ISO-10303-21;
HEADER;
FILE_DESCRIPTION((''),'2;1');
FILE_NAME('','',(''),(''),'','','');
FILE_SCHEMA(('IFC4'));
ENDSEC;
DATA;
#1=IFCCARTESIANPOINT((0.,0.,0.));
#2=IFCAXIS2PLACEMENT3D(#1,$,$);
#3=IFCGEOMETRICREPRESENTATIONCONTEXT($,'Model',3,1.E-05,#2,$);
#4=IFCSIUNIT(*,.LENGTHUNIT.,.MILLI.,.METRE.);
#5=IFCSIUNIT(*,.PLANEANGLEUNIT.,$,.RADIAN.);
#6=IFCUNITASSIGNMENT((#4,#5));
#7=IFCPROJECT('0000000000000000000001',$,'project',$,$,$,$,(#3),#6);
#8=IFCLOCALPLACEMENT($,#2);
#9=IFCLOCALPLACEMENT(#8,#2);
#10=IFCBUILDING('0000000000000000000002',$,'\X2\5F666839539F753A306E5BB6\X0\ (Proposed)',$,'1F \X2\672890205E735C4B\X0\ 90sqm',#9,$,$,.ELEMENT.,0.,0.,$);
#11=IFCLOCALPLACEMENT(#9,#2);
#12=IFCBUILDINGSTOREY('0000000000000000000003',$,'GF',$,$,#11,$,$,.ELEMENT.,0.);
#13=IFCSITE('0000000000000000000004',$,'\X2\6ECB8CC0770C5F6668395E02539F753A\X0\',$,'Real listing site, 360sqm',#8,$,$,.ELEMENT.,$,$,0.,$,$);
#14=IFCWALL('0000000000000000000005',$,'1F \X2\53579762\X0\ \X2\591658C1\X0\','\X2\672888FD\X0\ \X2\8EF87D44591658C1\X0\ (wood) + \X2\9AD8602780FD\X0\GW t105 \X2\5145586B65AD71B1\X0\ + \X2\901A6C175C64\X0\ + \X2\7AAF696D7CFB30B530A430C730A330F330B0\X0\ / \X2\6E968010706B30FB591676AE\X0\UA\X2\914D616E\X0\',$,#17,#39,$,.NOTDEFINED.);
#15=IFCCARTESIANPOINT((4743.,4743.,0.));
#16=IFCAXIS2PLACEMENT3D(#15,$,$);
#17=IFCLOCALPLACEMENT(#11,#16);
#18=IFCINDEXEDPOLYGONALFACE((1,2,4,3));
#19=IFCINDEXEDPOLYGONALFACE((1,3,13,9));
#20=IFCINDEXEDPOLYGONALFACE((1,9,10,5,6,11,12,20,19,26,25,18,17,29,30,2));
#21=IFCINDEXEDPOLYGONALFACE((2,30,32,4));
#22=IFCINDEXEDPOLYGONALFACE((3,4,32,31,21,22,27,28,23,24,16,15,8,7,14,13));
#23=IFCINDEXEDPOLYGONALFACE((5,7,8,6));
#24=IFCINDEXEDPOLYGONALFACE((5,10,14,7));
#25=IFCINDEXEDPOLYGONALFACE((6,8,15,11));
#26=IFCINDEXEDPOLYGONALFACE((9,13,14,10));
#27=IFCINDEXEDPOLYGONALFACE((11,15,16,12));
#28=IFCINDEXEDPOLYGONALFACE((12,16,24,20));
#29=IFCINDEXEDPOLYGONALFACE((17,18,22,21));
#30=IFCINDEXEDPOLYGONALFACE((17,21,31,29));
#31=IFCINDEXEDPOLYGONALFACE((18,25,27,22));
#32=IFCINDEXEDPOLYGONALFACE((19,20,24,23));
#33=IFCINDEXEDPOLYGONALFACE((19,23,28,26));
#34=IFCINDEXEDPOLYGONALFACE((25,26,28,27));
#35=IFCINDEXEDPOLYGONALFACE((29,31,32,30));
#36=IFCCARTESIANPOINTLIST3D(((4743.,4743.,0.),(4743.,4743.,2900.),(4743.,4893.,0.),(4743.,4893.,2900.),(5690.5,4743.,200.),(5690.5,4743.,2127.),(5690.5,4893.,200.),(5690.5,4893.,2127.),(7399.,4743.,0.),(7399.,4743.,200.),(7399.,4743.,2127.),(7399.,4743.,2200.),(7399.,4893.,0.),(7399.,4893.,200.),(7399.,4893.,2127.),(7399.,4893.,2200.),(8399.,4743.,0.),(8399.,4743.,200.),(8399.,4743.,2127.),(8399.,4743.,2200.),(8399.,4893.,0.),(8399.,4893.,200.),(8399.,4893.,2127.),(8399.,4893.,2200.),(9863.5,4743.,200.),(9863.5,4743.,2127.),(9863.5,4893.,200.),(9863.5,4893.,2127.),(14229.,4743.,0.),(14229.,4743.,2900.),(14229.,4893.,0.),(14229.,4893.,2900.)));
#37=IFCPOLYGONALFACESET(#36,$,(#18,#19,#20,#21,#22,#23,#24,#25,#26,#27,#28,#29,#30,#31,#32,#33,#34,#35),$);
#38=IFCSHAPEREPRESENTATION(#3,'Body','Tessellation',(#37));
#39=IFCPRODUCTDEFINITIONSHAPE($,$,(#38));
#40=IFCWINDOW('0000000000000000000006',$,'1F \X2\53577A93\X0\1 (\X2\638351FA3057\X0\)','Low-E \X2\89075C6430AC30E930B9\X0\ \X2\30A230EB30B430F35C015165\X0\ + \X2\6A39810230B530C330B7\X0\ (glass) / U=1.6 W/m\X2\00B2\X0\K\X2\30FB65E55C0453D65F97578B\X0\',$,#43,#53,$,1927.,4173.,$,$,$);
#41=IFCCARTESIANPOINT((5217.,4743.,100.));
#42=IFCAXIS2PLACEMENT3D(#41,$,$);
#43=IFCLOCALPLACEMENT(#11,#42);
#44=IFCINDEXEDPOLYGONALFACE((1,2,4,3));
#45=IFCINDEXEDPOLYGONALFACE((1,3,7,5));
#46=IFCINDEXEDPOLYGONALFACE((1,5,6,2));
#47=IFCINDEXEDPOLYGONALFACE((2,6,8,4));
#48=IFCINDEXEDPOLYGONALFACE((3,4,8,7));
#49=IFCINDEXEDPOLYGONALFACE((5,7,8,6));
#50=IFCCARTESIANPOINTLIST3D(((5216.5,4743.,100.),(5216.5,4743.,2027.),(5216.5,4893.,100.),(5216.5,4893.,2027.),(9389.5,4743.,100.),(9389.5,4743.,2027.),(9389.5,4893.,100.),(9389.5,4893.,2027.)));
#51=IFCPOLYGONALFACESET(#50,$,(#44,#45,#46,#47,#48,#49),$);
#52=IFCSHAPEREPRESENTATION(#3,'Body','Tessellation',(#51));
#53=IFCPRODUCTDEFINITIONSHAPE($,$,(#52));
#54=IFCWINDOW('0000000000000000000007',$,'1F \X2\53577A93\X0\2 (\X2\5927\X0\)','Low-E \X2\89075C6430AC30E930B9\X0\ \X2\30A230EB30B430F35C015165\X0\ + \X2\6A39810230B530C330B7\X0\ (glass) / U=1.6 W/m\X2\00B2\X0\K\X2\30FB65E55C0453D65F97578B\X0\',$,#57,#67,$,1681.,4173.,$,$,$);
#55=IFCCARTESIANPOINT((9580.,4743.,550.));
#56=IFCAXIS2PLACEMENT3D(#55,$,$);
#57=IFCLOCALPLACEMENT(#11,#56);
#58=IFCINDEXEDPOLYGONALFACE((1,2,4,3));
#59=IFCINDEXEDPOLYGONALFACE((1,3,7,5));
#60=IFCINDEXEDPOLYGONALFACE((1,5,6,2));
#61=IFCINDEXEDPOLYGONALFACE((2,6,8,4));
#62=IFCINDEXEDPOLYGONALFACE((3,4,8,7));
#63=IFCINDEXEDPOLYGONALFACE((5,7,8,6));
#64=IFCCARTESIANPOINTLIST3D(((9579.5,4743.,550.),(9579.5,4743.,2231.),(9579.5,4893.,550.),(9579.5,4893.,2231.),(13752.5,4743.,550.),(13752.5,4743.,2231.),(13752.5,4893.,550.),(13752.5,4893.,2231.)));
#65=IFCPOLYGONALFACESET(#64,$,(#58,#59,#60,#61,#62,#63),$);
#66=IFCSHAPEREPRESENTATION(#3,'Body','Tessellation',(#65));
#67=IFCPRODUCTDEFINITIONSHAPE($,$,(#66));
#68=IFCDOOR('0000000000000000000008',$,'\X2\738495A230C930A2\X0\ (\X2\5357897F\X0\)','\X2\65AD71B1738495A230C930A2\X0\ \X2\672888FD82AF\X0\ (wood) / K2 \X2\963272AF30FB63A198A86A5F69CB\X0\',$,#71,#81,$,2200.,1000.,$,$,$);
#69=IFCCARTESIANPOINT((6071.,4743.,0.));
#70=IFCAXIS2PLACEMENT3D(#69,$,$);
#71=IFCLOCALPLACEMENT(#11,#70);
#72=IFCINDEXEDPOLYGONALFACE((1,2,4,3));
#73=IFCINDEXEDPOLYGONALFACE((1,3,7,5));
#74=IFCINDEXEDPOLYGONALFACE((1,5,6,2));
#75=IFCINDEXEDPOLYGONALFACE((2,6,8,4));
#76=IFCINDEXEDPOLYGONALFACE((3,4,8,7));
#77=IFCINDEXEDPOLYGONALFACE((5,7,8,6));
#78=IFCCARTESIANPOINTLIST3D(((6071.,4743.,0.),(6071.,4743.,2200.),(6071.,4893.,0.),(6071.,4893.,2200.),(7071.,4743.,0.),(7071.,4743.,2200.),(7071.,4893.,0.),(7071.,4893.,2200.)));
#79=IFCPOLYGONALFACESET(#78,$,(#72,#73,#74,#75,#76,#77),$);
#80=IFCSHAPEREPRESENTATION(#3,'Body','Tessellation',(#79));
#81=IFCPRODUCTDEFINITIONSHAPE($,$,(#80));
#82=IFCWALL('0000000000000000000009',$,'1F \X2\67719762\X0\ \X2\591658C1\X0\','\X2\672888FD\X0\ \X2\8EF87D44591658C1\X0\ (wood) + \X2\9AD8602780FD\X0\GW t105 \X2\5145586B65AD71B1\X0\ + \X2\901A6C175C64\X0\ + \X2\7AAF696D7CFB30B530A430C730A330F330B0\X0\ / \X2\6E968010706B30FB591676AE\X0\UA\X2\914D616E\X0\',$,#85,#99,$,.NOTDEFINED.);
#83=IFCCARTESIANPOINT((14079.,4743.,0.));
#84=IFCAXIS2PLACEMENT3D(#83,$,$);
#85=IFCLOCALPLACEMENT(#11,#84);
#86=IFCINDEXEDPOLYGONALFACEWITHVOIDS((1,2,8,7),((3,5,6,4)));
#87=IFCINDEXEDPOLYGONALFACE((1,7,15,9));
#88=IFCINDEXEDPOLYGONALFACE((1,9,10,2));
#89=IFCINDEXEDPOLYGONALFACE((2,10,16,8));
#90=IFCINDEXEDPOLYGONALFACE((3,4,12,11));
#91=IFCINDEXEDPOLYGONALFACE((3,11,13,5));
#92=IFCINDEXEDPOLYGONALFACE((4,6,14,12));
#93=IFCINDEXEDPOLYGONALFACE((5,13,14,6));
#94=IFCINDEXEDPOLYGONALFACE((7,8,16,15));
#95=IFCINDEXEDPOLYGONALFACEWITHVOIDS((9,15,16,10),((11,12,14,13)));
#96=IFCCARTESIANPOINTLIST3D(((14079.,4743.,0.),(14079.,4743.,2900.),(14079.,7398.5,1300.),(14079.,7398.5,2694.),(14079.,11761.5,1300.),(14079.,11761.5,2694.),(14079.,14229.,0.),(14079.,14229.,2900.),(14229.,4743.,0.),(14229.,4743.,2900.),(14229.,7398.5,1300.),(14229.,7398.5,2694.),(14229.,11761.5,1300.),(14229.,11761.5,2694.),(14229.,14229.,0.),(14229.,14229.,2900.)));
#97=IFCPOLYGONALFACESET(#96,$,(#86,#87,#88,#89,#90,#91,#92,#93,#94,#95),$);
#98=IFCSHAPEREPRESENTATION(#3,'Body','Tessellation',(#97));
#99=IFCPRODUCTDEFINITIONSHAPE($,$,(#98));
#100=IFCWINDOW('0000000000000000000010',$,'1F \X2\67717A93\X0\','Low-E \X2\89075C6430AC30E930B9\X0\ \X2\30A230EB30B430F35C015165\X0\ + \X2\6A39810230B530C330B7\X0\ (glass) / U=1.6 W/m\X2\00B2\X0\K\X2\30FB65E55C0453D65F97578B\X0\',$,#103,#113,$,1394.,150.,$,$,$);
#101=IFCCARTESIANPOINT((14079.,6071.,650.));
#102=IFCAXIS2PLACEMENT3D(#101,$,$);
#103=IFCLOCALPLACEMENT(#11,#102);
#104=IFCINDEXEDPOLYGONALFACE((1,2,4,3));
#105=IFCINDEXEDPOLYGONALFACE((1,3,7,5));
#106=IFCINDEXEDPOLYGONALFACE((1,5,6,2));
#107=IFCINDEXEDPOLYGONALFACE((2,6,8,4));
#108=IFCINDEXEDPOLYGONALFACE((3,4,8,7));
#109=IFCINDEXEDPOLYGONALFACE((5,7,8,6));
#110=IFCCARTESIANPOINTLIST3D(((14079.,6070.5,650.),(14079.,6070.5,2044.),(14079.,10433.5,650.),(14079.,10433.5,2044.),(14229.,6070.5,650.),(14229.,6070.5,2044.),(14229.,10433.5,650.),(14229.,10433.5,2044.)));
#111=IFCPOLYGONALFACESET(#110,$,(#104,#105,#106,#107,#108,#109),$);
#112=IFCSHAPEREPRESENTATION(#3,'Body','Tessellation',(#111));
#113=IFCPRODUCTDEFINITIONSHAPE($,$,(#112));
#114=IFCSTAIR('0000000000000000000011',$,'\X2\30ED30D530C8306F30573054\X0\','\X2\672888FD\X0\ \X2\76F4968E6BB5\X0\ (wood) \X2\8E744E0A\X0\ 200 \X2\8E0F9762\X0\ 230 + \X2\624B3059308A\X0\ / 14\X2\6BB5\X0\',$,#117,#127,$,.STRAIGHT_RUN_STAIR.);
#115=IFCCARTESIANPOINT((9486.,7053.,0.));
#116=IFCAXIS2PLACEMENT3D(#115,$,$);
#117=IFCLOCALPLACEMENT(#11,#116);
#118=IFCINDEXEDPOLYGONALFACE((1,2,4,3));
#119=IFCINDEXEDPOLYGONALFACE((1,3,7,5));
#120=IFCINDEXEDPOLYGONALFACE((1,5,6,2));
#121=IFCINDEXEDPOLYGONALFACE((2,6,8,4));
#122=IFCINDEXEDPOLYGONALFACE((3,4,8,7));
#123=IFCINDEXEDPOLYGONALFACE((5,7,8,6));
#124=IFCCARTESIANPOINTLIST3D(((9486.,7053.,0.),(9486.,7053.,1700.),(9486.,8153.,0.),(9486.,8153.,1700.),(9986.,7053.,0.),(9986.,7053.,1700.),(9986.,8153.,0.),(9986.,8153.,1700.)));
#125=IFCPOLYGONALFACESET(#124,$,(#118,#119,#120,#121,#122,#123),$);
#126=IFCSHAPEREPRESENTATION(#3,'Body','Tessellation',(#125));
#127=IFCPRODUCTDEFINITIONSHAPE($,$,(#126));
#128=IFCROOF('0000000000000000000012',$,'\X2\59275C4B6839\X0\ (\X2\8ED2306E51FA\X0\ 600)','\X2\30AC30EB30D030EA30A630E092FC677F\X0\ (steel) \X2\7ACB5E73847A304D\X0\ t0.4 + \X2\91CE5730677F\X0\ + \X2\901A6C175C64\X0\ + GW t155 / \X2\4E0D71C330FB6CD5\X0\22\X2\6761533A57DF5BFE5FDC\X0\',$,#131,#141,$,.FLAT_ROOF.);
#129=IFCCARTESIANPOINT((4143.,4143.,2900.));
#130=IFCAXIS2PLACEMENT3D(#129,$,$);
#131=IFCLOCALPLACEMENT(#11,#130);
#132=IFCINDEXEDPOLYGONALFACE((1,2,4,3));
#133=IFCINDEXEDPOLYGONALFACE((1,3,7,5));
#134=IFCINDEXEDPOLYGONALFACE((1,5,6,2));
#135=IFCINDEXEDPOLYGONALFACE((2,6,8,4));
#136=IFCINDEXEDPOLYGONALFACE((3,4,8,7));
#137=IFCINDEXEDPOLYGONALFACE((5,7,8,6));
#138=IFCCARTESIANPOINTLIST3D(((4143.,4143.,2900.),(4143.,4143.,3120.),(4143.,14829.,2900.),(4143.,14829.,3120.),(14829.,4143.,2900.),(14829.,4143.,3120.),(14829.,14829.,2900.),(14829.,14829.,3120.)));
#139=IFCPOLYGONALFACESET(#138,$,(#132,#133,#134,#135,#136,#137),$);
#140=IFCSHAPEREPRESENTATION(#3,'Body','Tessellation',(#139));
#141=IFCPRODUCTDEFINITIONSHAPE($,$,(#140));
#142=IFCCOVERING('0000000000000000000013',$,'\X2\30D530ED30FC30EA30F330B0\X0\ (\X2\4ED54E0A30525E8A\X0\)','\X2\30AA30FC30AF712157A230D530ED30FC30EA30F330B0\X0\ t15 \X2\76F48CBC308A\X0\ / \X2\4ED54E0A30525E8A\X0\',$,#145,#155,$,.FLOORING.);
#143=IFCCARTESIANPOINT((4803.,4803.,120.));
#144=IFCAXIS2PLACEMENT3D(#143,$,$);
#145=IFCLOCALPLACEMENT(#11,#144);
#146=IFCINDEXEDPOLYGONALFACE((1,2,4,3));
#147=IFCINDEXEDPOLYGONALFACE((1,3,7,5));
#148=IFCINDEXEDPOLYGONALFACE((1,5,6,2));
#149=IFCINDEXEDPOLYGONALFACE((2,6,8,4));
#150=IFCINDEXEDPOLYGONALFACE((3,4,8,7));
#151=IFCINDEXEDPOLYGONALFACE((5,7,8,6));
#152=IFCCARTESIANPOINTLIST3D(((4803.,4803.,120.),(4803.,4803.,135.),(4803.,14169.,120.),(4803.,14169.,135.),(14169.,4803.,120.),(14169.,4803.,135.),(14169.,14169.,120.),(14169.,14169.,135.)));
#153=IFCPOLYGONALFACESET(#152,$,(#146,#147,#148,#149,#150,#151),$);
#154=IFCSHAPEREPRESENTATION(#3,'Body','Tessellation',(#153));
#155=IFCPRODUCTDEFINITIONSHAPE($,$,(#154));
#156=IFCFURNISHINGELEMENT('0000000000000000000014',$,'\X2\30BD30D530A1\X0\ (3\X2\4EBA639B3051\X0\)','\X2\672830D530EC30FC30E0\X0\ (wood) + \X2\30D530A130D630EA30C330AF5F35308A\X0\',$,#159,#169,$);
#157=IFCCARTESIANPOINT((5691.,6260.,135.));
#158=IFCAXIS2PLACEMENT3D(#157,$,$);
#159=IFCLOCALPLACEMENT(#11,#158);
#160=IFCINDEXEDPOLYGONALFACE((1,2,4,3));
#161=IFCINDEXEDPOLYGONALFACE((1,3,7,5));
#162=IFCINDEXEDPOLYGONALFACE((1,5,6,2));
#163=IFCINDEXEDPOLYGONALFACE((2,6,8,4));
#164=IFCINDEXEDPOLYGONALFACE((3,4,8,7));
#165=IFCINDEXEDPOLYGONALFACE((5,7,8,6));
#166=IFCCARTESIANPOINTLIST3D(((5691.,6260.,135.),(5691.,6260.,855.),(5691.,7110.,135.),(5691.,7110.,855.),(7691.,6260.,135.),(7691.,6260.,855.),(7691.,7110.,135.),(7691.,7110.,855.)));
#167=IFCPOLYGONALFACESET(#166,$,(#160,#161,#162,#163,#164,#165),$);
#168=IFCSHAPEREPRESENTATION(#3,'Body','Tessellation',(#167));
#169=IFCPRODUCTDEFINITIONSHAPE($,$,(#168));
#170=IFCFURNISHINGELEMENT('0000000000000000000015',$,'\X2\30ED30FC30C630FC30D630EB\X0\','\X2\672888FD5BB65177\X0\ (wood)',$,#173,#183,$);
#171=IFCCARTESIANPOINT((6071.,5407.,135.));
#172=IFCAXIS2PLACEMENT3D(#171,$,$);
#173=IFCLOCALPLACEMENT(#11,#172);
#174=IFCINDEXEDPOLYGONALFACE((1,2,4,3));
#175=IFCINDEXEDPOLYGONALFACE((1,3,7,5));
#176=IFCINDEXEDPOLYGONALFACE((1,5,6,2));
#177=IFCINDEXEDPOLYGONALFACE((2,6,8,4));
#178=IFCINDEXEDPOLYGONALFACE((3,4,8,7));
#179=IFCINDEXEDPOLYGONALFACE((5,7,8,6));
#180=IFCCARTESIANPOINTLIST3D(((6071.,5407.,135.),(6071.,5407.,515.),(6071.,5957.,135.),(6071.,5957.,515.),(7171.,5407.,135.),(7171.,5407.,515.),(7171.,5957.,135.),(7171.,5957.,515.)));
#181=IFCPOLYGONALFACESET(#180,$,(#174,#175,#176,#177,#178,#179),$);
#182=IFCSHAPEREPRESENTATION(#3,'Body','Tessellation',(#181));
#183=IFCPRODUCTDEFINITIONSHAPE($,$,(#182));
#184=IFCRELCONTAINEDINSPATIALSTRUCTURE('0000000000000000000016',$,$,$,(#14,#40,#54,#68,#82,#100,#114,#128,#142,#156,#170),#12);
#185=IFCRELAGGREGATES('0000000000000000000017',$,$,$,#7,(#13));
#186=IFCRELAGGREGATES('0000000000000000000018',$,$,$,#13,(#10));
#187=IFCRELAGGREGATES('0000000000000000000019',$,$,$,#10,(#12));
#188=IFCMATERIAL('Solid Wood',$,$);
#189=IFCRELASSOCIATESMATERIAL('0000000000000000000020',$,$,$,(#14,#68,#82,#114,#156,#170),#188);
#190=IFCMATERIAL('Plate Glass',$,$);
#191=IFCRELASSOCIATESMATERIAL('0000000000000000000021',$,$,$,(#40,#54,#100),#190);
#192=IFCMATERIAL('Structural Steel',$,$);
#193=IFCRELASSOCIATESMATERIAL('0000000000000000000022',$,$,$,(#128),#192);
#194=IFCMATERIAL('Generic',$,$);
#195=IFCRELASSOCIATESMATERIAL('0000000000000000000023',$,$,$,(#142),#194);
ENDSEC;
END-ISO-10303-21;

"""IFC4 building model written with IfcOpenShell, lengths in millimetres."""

from ifc_helpers import new_model, si_unit, frame, frame_2d, origin, place, context, project, spatial, rectangle, extrude, material, element, fill, save


model = new_model("IFC4")

# Units and contexts
model_context = context("Model", 3, precision=1e-05, world=origin())
ifc_project = project(units=[si_unit("LENGTHUNIT", "METRE", prefix="MILLI"), si_unit("PLANEANGLEUNIT", "RADIAN")], contexts=[model_context])

# Site, building, storey
site_placement = place(None, origin())
site = spatial("IfcSite", under=ifc_project, at=site_placement, Name="滋賀県彦根市原町", ObjectType="Real listing site, 360sqm", CompositionType="ELEMENT", RefElevation=0.0)
building_placement = place(site_placement, origin())
building = spatial("IfcBuilding", under=site, at=building_placement, Name="彦根原町の家 (Proposed)", ObjectType="1F 木造平屋 90sqm", CompositionType="ELEMENT", ElevationOfRefHeight=0.0, ElevationOfTerrain=0.0)
storey_placement = place(building_placement, origin())
storey = spatial("IfcBuildingStorey", under=building, at=storey_placement, Name="GF", CompositionType="ELEMENT", Elevation=0.0)

# Shared definitions
ifc_material_1 = material(Name="Solid Wood")

# Wall, openings, windows, door
wall_1_placement = place(storey_placement, frame((4743.0, 4743.0, 0.0)))
wall_1 = element("IfcWall", 1, at=wall_1_placement, inside=storey, material=ifc_material_1, Name="1F 南面 外壁", Description="木製 軸組外壁 (wood) + 高性能GW t105 充填断熱 + 通気層 + 窯業系サイディング / 準耐火・外皮UA配慮", PredefinedType="NOTDEFINED", context=model_context, shape_type="SweptSolid", body=[
    extrude(rectangle(XDim=9486.0, YDim=150.0, at=frame_2d((4743.0, 75.0))), frame((4743.0, 4743.0, 0.0)), (0.0, 0.0, 1.0), 2900.0),
])
opening_1_placement = place(storey_placement, frame((5217.0, 4743.0, 100.0)))
opening_1 = element("IfcOpeningElement", 2, at=opening_1_placement, cuts=wall_1, PredefinedType="NOTDEFINED", context=model_context, shape_type="SweptSolid", body=[
    extrude(rectangle(XDim=4173.0, YDim=150.0, at=frame_2d((2086.0, 75.0))), frame((5217.0, 4743.0, 100.0)), (0.0, 0.0, 1.0), 1927.0),
])
opening_2_placement = place(storey_placement, frame((9580.0, 4743.0, 550.0)))
opening_2 = element("IfcOpeningElement", 3, at=opening_2_placement, cuts=wall_1, PredefinedType="NOTDEFINED", context=model_context, shape_type="SweptSolid", body=[
    extrude(rectangle(XDim=4173.0, YDim=150.0, at=frame_2d((2086.0, 75.0))), frame((9580.0, 4743.0, 550.0)), (0.0, 0.0, 1.0), 1681.0),
])
opening_3_placement = place(storey_placement, frame((6071.0, 4743.0, 0.0)))
opening_3 = element("IfcOpeningElement", 4, at=opening_3_placement, cuts=wall_1, PredefinedType="NOTDEFINED", context=model_context, shape_type="SweptSolid", body=[
    extrude(rectangle(XDim=1000.0, YDim=150.0, at=frame_2d((500.0, 75.0))), frame((6071.0, 4743.0, 0.0)), (0.0, 0.0, 1.0), 2200.0),
])
ifc_material_2 = material(Name="Plate Glass")
window_1_placement = place(storey_placement, frame((5217.0, 4743.0, 100.0)))
window_1 = element("IfcWindow", 5, at=window_1_placement, inside=storey, material=ifc_material_2, Name="1F 南窓1 (掃出し)", Description="Low-E 複層ガラス アルゴン封入 + 樹脂サッシ (glass) / U=1.6 W/m²K・日射取得型", OverallHeight=1927.0, OverallWidth=4173.0, context=model_context, shape_type="SweptSolid", body=[
    extrude(rectangle(XDim=4173.0, YDim=150.0, at=frame_2d((2086.0, 75.0))), frame((5217.0, 4743.0, 100.0)), (0.0, 0.0, 1.0), 1927.0),
])
fill(opening_1, window_1)
window_2_placement = place(storey_placement, frame((9580.0, 4743.0, 550.0)))
window_2 = element("IfcWindow", 6, at=window_2_placement, inside=storey, material=ifc_material_2, Name="1F 南窓2 (大)", Description="Low-E 複層ガラス アルゴン封入 + 樹脂サッシ (glass) / U=1.6 W/m²K・日射取得型", OverallHeight=1681.0, OverallWidth=4173.0, context=model_context, shape_type="SweptSolid", body=[
    extrude(rectangle(XDim=4173.0, YDim=150.0, at=frame_2d((2086.0, 75.0))), frame((9580.0, 4743.0, 550.0)), (0.0, 0.0, 1.0), 1681.0),
])
fill(opening_2, window_2)
door_placement = place(storey_placement, frame((6071.0, 4743.0, 0.0)))
door = element("IfcDoor", 7, at=door_placement, inside=storey, material=ifc_material_1, Name="玄関ドア (南西)", Description="断熱玄関ドア 木製芯 (wood) / K2 防犯・採風機構", OverallHeight=2200.0, OverallWidth=1000.0, context=model_context, shape_type="SweptSolid", body=[
    extrude(rectangle(XDim=1000.0, YDim=150.0, at=frame_2d((500.0, 75.0))), frame((6071.0, 4743.0, 0.0)), (0.0, 0.0, 1.0), 2200.0),
])
fill(opening_3, door)

# Wall, opening, window
wall_2_placement = place(storey_placement, frame((14079.0, 4743.0, 0.0)))
wall_2 = element("IfcWall", 8, at=wall_2_placement, inside=storey, material=ifc_material_1, Name="1F 東面 外壁", Description="木製 軸組外壁 (wood) + 高性能GW t105 充填断熱 + 通気層 + 窯業系サイディング / 準耐火・外皮UA配慮", PredefinedType="NOTDEFINED", context=model_context, shape_type="SweptSolid", body=[
    extrude(rectangle(XDim=150.0, YDim=9486.0, at=frame_2d((75.0, 4743.0))), frame((14079.0, 4743.0, 0.0)), (0.0, 0.0, 1.0), 2900.0),
])
opening_4_placement = place(storey_placement, frame((14079.0, 6071.0, 650.0)))
opening_4 = element("IfcOpeningElement", 9, at=opening_4_placement, cuts=wall_2, PredefinedType="NOTDEFINED", context=model_context, shape_type="SweptSolid", body=[
    extrude(rectangle(XDim=150.0, YDim=4363.0, at=frame_2d((75.0, 2181.0))), frame((14079.0, 6071.0, 650.0)), (0.0, 0.0, 1.0), 1394.0),
])
window_3_placement = place(storey_placement, frame((14079.0, 6071.0, 650.0)))
window_3 = element("IfcWindow", 10, at=window_3_placement, inside=storey, material=ifc_material_2, Name="1F 東窓", Description="Low-E 複層ガラス アルゴン封入 + 樹脂サッシ (glass) / U=1.6 W/m²K・日射取得型", OverallHeight=1394.0, OverallWidth=150.0, context=model_context, shape_type="SweptSolid", body=[
    extrude(rectangle(XDim=150.0, YDim=4363.0, at=frame_2d((75.0, 2181.0))), frame((14079.0, 6071.0, 650.0)), (0.0, 0.0, 1.0), 1394.0),
])
fill(opening_4, window_3)

# Stair
stair_placement = place(storey_placement, frame((9486.0, 7053.0, 0.0)))
element("IfcStair", 11, at=stair_placement, inside=storey, material=ifc_material_1, Name="ロフトはしご", Description="木製 直階段 (wood) 蹴上 200 踏面 230 + 手すり / 14段", PredefinedType="STRAIGHT_RUN_STAIR", context=model_context, shape_type="SweptSolid", body=[
    extrude(rectangle(XDim=500.0, YDim=1100.0, at=frame_2d((250.0, 550.0))), frame((9486.0, 7053.0, 0.0)), (0.0, 0.0, 1.0), 1700.0),
])

# Roof
ifc_material_3 = material(Name="Structural Steel")
roof_placement = place(storey_placement, frame((4143.0, 4143.0, 2900.0)))
element("IfcRoof", 12, at=roof_placement, inside=storey, material=ifc_material_3, Name="大屋根 (軒の出 600)", Description="ガルバリウム鋼板 (steel) 立平葺き t0.4 + 野地板 + 通気層 + GW t155 / 不燃・法22条区域対応", PredefinedType="FLAT_ROOF", context=model_context, shape_type="SweptSolid", body=[
    extrude(rectangle(XDim=10686.0, YDim=10686.0, at=frame_2d((5343.0, 5343.0))), frame((4143.0, 4143.0, 2900.0)), (0.0, 0.0, 1.0), 220.0),
])

# Covering
ifc_material_4 = material(Name="Generic")
covering_placement = place(storey_placement, frame((4803.0, 4803.0, 120.0)))
element("IfcCovering", 13, at=covering_placement, inside=storey, material=ifc_material_4, Name="フローリング (仕上げ床)", Description="オーク無垢フローリング t15 直貼り / 仕上げ床", PredefinedType="FLOORING", context=model_context, shape_type="SweptSolid", body=[
    extrude(rectangle(XDim=9366.0, YDim=9366.0, at=frame_2d((4683.0, 4683.0))), frame((4803.0, 4803.0, 120.0)), (0.0, 0.0, 1.0), 15.0),
])

# Furnishing elements
furnishing_1_placement = place(storey_placement, frame((5691.0, 6260.0, 135.0)))
element("IfcFurnishingElement", 14, at=furnishing_1_placement, inside=storey, material=ifc_material_1, Name="ソファ (3人掛け)", Description="木フレーム (wood) + ファブリック張り", context=model_context, shape_type="SweptSolid", body=[
    extrude(rectangle(XDim=2000.0, YDim=850.0, at=frame_2d((1000.0, 425.0))), frame((5691.0, 6260.0, 135.0)), (0.0, 0.0, 1.0), 720.0),
])
furnishing_2_placement = place(storey_placement, frame((6071.0, 5407.0, 135.0)))
element("IfcFurnishingElement", 15, at=furnishing_2_placement, inside=storey, material=ifc_material_1, Name="ローテーブル", Description="木製家具 (wood)", context=model_context, shape_type="SweptSolid", body=[
    extrude(rectangle(XDim=1100.0, YDim=550.0, at=frame_2d((550.0, 275.0))), frame((6071.0, 5407.0, 135.0)), (0.0, 0.0, 1.0), 380.0),
])

save(model, "model.ifc")
